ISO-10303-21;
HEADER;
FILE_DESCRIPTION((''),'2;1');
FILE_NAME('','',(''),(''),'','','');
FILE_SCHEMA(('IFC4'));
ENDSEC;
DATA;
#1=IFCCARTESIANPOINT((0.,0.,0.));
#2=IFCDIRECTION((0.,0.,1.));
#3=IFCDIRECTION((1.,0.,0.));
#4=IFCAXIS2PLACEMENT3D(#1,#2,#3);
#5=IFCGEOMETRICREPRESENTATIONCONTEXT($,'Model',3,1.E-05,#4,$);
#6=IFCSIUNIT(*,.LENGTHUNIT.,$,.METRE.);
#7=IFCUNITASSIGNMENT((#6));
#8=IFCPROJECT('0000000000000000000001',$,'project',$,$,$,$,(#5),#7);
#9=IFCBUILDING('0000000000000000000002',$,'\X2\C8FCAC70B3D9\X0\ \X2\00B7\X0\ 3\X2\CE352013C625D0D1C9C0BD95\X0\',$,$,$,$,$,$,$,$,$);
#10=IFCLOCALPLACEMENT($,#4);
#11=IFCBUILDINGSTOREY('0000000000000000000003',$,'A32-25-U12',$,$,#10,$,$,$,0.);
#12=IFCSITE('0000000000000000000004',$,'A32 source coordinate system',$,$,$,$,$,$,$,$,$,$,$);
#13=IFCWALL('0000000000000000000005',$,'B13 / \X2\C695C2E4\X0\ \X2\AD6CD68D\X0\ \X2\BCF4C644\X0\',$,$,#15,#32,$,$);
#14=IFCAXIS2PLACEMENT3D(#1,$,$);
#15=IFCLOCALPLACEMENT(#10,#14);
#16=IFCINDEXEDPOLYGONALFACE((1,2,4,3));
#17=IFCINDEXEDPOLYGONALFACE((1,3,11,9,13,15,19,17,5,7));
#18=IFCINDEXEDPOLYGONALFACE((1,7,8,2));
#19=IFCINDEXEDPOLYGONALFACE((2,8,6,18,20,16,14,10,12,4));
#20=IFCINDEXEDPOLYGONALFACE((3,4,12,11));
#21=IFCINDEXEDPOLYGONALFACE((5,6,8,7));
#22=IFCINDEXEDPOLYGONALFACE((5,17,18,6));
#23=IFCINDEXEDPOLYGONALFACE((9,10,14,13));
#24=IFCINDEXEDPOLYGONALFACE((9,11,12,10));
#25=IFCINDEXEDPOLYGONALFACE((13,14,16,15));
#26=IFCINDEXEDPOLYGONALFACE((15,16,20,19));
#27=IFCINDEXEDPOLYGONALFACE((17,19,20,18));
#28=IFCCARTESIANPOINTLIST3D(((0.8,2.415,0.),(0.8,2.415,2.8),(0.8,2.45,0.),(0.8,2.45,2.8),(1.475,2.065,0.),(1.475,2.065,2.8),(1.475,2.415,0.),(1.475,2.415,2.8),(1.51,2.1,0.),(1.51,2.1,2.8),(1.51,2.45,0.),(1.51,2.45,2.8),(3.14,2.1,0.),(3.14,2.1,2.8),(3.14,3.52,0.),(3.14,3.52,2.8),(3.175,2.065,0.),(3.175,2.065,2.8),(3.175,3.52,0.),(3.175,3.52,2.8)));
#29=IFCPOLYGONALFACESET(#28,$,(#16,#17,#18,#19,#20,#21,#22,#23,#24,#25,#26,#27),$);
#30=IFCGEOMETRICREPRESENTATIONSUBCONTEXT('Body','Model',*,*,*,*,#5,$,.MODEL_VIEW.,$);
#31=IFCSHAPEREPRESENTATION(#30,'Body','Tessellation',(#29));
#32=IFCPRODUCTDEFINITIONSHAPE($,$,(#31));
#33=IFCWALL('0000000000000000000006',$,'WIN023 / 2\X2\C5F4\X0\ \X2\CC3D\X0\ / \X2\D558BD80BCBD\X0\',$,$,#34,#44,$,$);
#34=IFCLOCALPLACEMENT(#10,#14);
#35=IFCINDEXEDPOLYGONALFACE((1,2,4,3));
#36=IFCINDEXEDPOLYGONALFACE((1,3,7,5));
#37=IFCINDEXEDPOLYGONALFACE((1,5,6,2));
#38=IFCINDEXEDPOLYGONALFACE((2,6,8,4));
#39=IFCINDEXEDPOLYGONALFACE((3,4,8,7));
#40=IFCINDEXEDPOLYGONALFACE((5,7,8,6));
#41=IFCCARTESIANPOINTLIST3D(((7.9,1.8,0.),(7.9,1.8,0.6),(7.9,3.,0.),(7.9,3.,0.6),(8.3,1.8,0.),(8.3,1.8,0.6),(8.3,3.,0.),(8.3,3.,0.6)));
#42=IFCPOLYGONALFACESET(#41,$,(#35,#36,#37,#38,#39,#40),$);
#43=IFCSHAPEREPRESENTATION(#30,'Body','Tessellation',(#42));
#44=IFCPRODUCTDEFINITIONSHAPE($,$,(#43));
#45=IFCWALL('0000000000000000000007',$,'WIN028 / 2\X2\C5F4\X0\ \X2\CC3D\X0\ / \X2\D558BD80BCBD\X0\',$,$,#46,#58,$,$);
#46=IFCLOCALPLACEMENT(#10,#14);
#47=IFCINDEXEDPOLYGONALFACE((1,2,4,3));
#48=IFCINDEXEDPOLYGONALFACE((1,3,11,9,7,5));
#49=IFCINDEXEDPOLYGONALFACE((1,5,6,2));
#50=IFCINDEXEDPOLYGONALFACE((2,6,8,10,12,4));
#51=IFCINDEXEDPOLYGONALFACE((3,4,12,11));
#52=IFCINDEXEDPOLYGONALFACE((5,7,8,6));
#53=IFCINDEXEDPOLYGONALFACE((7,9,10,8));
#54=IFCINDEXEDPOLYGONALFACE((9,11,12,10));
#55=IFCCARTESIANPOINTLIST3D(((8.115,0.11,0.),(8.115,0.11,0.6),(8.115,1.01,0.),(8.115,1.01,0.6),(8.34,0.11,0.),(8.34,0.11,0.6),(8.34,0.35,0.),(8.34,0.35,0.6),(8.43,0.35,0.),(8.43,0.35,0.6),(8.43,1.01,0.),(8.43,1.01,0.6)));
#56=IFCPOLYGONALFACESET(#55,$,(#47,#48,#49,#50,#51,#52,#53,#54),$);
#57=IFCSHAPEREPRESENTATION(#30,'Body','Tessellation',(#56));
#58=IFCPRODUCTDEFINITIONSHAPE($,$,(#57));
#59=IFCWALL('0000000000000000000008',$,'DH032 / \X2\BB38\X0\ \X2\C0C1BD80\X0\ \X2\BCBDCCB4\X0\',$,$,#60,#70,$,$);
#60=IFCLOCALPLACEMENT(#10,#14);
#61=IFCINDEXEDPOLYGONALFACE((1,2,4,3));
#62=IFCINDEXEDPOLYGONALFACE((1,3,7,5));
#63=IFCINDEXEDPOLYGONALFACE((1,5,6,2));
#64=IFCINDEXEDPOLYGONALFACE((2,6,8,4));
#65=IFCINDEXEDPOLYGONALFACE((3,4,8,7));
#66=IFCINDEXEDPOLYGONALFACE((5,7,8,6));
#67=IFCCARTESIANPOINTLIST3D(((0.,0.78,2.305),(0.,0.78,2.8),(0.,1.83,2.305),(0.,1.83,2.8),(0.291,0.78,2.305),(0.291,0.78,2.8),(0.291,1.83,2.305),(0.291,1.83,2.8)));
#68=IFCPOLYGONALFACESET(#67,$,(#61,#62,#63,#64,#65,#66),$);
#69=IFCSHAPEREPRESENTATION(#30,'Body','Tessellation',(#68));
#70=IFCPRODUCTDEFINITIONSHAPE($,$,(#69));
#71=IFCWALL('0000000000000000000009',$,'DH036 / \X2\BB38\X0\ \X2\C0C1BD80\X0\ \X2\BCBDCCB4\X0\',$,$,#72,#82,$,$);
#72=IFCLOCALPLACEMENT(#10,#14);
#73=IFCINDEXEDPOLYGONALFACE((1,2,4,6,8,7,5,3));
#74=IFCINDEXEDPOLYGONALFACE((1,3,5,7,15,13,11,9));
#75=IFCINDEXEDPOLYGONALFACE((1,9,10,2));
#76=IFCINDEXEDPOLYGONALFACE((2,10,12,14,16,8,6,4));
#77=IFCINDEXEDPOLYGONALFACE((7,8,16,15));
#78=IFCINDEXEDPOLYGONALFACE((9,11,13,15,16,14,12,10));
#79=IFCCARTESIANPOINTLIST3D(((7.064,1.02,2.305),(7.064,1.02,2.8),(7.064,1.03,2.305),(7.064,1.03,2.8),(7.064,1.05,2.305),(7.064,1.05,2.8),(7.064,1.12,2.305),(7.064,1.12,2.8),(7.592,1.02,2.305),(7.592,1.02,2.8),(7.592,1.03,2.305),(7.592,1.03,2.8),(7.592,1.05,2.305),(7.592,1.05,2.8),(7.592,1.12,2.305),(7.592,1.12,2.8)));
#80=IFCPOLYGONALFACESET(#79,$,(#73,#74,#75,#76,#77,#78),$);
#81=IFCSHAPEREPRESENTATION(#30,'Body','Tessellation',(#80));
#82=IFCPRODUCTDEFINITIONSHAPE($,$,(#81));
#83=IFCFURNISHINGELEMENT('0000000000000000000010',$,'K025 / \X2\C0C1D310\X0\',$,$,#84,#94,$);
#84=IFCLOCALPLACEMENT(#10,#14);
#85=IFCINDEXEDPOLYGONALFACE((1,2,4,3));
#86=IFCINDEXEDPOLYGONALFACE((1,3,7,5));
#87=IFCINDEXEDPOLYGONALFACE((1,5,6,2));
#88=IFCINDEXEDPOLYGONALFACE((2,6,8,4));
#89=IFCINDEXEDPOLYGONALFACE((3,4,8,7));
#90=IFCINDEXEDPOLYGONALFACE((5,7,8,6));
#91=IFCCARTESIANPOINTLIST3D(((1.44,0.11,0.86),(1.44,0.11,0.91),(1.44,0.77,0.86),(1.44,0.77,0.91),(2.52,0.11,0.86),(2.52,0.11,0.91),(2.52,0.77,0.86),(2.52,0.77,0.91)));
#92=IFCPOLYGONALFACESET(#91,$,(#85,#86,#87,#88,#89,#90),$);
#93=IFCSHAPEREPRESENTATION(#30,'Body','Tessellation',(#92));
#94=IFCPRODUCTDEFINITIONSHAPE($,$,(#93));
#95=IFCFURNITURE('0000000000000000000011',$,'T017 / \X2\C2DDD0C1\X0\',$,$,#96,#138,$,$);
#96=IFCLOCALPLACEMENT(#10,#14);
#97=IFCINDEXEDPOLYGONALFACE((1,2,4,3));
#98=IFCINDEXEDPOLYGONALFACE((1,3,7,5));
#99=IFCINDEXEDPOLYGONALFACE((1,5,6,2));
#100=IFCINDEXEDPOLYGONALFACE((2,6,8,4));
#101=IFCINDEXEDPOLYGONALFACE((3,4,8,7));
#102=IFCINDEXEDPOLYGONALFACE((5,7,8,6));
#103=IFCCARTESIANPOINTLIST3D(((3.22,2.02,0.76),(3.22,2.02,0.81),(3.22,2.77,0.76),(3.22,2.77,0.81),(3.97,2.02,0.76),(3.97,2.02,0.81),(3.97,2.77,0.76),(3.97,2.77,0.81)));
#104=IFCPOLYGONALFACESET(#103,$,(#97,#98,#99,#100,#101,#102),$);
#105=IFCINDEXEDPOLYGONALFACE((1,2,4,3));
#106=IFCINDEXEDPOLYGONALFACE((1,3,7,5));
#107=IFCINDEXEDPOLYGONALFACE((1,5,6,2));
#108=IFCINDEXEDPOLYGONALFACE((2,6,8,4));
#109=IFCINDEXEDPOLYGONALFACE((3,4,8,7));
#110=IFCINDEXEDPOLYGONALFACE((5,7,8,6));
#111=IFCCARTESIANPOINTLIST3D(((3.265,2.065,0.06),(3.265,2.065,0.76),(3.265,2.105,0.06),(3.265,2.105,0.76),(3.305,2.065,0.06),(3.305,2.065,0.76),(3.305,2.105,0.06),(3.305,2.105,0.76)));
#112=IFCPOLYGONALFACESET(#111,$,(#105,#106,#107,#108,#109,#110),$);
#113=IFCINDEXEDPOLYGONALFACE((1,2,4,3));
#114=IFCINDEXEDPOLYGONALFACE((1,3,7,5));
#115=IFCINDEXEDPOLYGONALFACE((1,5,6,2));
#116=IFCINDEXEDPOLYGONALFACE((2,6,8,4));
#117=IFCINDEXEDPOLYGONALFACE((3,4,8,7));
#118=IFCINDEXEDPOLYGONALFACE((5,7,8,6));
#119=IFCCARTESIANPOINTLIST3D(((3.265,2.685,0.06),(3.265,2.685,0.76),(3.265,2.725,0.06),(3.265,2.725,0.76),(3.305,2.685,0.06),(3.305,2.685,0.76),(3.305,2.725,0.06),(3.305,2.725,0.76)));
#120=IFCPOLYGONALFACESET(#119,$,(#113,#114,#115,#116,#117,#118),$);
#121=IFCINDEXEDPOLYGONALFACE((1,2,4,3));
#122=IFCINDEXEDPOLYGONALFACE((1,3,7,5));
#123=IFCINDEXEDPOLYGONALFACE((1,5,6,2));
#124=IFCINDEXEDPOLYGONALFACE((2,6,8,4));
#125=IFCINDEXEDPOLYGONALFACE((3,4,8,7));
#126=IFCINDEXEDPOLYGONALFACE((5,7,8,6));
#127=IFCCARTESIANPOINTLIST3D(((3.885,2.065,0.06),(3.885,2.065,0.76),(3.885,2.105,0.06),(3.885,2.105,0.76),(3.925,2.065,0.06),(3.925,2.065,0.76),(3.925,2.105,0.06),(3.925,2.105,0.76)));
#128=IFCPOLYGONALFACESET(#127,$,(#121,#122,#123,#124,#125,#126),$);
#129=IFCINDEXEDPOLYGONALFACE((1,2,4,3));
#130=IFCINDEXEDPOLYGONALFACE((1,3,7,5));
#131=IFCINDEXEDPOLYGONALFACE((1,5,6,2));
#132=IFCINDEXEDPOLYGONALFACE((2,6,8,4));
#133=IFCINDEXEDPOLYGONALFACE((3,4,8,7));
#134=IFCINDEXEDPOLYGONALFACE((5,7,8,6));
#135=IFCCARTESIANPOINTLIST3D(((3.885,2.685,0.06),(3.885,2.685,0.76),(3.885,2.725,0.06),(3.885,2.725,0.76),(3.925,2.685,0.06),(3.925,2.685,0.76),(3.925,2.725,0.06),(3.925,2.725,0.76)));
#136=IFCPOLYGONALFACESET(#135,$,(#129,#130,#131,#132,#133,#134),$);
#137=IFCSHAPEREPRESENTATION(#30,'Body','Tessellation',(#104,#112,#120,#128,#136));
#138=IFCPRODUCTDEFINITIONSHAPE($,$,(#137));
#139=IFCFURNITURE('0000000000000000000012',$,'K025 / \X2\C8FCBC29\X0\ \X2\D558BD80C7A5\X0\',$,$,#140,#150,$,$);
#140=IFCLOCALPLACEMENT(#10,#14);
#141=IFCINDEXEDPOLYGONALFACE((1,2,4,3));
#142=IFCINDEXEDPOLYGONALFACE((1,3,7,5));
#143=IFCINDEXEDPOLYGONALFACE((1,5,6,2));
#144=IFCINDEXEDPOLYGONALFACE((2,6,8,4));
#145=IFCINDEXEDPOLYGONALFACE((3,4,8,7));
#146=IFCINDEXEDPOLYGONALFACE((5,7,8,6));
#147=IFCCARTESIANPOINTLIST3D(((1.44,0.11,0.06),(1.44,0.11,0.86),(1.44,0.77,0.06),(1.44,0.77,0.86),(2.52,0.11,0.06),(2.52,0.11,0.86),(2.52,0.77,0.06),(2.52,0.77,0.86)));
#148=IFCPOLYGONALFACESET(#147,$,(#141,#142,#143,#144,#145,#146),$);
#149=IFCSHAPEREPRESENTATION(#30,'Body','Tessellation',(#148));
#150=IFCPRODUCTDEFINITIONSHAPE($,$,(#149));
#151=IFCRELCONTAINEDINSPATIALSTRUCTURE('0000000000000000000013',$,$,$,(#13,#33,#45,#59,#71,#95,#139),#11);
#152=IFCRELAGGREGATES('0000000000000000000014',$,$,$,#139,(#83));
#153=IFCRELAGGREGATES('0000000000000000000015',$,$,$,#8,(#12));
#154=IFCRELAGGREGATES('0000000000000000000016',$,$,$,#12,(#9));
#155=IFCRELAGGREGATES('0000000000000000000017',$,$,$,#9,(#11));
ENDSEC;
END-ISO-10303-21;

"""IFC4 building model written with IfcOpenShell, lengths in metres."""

from ifc_helpers import new_model, si_unit, frame, origin, origin_with_axes, place, context, subcontext, project, spatial, polyline, outline, extrude, element, aggregate, save


model = new_model("IFC4")

# Units and contexts
model_context = context("Model", 3, precision=1e-05, world=origin_with_axes())
body_context = subcontext(model_context, "Body", "Model", "MODEL_VIEW")
ifc_project = project(units=[si_unit("LENGTHUNIT", "METRE")], contexts=[model_context])

# Site, building, storey
site = spatial("IfcSite", under=ifc_project, Name="A32 source coordinate system")
building = spatial("IfcBuilding", under=site, Name="주거동 · 3층–옥탑지붕")
storey_placement = place(None, origin_with_axes())
storey = spatial("IfcBuildingStorey", under=building, at=storey_placement, Name="A32-25-U12", Elevation=0.0)

# Walls
wall_1_placement = place(storey_placement, origin_with_axes())
element("IfcWall", 1, at=wall_1_placement, inside=storey, Name="B13 / 욕실 구획 보완", context=body_context, shape_type="SweptSolid", body=[
    extrude(outline(polyline([(0.8, 2.45), (1.51, 2.45), (1.51, 2.1), (3.14, 2.1), (3.14, 3.52), (3.175, 3.52), (3.175, 2.065), (1.475, 2.065), (1.475, 2.415), (0.8, 2.415), (0.8, 2.45)])), origin(), (0.0, 0.0, 1.0), 2.8),
])
wall_2_placement = place(storey_placement, origin_with_axes())
element("IfcWall", 2, at=wall_2_placement, inside=storey, Name="WIN023 / 2열 창 / 하부벽", context=body_context, shape_type="SweptSolid", body=[
    extrude(outline(polyline([(7.9, 1.8), (7.9, 3.0), (8.3, 3.0), (8.3, 1.8), (7.9, 1.8)])), origin(), (0.0, 0.0, 1.0), 0.6),
])
wall_3_placement = place(storey_placement, origin_with_axes())
element("IfcWall", 3, at=wall_3_placement, inside=storey, Name="WIN028 / 2열 창 / 하부벽", context=body_context, shape_type="SweptSolid", body=[
    extrude(outline(polyline([(8.34, 0.35), (8.34, 0.11), (8.115, 0.11), (8.115, 1.01), (8.43, 1.01), (8.43, 0.35), (8.34, 0.35)])), origin(), (0.0, 0.0, 1.0), 0.6),
])
wall_4_placement = place(storey_placement, origin_with_axes())
element("IfcWall", 4, at=wall_4_placement, inside=storey, Name="DH032 / 문 상부 벽체", context=body_context, shape_type="SweptSolid", body=[
    extrude(outline(polyline([(0.0, 1.83), (0.291, 1.83), (0.291, 0.78), (0.0, 0.78), (0.0, 1.83)])), frame((0.0, 0.0, 2.305)), (0.0, 0.0, 1.0), 0.495),
])
wall_5_placement = place(storey_placement, origin_with_axes())
element("IfcWall", 5, at=wall_5_placement, inside=storey, Name="DH036 / 문 상부 벽체", context=body_context, shape_type="SweptSolid", body=[
    extrude(outline(polyline([(7.064, 1.03), (7.064, 1.05), (7.064, 1.12), (7.592, 1.12), (7.592, 1.05), (7.592, 1.03), (7.592, 1.02), (7.064, 1.02), (7.064, 1.03)])), frame((0.0, 0.0, 2.305)), (0.0, 0.0, 1.0), 0.495),
])

# Furnishing element
furniture_1_placement = place(storey_placement, origin_with_axes())
furnishing_1_placement = place(furniture_1_placement, origin_with_axes())
furnishing_1 = element("IfcFurnishingElement", 6, at=furnishing_1_placement, Name="K025 / 상판", context=body_context, shape_type="SweptSolid", body=[
    extrude(outline(polyline([(2.52, 0.77), (2.52, 0.11), (1.44, 0.11), (1.44, 0.77), (2.52, 0.77)])), frame((0.0, 0.0, 0.86)), (0.0, 0.0, 1.0), 0.05),
])

# Furniture
furniture_2_placement = place(storey_placement, origin_with_axes())
element("IfcFurniture", 7, at=furniture_2_placement, inside=storey, Name="T017 / 식탁", context=body_context, shape_type="SweptSolid", body=[
    extrude(outline(polyline([(3.97, 2.02), (3.22, 2.02), (3.22, 2.77), (3.97, 2.77), (3.97, 2.02)])), frame((0.0, 0.0, 0.76)), (0.0, 0.0, 1.0), 0.05),
    extrude(outline(polyline([(3.265, 2.065), (3.265, 2.105), (3.305, 2.105), (3.305, 2.065), (3.265, 2.065)])), frame((0.0, 0.0, 0.06)), (0.0, 0.0, 1.0), 0.7),
    extrude(outline(polyline([(3.265, 2.685), (3.265, 2.725), (3.305, 2.725), (3.305, 2.685), (3.265, 2.685)])), frame((0.0, 0.0, 0.06)), (0.0, 0.0, 1.0), 0.7),
    extrude(outline(polyline([(3.885, 2.065), (3.885, 2.105), (3.925, 2.105), (3.925, 2.065), (3.885, 2.065)])), frame((0.0, 0.0, 0.06)), (0.0, 0.0, 1.0), 0.7),
    extrude(outline(polyline([(3.885, 2.685), (3.885, 2.725), (3.925, 2.725), (3.925, 2.685), (3.885, 2.685)])), frame((0.0, 0.0, 0.06)), (0.0, 0.0, 1.0), 0.7),
])
furniture_1 = element("IfcFurniture", 8, at=furniture_1_placement, inside=storey, Name="K025 / 주방 하부장", context=body_context, shape_type="SweptSolid", body=[
    extrude(outline(polyline([(1.44, 0.77), (2.52, 0.77), (2.52, 0.11), (1.44, 0.11), (1.44, 0.77)])), frame((0.0, 0.0, 0.06)), (0.0, 0.0, 1.0), 0.8),
])
aggregate(furniture_1, [furnishing_1])

save(model, "model.ifc")
